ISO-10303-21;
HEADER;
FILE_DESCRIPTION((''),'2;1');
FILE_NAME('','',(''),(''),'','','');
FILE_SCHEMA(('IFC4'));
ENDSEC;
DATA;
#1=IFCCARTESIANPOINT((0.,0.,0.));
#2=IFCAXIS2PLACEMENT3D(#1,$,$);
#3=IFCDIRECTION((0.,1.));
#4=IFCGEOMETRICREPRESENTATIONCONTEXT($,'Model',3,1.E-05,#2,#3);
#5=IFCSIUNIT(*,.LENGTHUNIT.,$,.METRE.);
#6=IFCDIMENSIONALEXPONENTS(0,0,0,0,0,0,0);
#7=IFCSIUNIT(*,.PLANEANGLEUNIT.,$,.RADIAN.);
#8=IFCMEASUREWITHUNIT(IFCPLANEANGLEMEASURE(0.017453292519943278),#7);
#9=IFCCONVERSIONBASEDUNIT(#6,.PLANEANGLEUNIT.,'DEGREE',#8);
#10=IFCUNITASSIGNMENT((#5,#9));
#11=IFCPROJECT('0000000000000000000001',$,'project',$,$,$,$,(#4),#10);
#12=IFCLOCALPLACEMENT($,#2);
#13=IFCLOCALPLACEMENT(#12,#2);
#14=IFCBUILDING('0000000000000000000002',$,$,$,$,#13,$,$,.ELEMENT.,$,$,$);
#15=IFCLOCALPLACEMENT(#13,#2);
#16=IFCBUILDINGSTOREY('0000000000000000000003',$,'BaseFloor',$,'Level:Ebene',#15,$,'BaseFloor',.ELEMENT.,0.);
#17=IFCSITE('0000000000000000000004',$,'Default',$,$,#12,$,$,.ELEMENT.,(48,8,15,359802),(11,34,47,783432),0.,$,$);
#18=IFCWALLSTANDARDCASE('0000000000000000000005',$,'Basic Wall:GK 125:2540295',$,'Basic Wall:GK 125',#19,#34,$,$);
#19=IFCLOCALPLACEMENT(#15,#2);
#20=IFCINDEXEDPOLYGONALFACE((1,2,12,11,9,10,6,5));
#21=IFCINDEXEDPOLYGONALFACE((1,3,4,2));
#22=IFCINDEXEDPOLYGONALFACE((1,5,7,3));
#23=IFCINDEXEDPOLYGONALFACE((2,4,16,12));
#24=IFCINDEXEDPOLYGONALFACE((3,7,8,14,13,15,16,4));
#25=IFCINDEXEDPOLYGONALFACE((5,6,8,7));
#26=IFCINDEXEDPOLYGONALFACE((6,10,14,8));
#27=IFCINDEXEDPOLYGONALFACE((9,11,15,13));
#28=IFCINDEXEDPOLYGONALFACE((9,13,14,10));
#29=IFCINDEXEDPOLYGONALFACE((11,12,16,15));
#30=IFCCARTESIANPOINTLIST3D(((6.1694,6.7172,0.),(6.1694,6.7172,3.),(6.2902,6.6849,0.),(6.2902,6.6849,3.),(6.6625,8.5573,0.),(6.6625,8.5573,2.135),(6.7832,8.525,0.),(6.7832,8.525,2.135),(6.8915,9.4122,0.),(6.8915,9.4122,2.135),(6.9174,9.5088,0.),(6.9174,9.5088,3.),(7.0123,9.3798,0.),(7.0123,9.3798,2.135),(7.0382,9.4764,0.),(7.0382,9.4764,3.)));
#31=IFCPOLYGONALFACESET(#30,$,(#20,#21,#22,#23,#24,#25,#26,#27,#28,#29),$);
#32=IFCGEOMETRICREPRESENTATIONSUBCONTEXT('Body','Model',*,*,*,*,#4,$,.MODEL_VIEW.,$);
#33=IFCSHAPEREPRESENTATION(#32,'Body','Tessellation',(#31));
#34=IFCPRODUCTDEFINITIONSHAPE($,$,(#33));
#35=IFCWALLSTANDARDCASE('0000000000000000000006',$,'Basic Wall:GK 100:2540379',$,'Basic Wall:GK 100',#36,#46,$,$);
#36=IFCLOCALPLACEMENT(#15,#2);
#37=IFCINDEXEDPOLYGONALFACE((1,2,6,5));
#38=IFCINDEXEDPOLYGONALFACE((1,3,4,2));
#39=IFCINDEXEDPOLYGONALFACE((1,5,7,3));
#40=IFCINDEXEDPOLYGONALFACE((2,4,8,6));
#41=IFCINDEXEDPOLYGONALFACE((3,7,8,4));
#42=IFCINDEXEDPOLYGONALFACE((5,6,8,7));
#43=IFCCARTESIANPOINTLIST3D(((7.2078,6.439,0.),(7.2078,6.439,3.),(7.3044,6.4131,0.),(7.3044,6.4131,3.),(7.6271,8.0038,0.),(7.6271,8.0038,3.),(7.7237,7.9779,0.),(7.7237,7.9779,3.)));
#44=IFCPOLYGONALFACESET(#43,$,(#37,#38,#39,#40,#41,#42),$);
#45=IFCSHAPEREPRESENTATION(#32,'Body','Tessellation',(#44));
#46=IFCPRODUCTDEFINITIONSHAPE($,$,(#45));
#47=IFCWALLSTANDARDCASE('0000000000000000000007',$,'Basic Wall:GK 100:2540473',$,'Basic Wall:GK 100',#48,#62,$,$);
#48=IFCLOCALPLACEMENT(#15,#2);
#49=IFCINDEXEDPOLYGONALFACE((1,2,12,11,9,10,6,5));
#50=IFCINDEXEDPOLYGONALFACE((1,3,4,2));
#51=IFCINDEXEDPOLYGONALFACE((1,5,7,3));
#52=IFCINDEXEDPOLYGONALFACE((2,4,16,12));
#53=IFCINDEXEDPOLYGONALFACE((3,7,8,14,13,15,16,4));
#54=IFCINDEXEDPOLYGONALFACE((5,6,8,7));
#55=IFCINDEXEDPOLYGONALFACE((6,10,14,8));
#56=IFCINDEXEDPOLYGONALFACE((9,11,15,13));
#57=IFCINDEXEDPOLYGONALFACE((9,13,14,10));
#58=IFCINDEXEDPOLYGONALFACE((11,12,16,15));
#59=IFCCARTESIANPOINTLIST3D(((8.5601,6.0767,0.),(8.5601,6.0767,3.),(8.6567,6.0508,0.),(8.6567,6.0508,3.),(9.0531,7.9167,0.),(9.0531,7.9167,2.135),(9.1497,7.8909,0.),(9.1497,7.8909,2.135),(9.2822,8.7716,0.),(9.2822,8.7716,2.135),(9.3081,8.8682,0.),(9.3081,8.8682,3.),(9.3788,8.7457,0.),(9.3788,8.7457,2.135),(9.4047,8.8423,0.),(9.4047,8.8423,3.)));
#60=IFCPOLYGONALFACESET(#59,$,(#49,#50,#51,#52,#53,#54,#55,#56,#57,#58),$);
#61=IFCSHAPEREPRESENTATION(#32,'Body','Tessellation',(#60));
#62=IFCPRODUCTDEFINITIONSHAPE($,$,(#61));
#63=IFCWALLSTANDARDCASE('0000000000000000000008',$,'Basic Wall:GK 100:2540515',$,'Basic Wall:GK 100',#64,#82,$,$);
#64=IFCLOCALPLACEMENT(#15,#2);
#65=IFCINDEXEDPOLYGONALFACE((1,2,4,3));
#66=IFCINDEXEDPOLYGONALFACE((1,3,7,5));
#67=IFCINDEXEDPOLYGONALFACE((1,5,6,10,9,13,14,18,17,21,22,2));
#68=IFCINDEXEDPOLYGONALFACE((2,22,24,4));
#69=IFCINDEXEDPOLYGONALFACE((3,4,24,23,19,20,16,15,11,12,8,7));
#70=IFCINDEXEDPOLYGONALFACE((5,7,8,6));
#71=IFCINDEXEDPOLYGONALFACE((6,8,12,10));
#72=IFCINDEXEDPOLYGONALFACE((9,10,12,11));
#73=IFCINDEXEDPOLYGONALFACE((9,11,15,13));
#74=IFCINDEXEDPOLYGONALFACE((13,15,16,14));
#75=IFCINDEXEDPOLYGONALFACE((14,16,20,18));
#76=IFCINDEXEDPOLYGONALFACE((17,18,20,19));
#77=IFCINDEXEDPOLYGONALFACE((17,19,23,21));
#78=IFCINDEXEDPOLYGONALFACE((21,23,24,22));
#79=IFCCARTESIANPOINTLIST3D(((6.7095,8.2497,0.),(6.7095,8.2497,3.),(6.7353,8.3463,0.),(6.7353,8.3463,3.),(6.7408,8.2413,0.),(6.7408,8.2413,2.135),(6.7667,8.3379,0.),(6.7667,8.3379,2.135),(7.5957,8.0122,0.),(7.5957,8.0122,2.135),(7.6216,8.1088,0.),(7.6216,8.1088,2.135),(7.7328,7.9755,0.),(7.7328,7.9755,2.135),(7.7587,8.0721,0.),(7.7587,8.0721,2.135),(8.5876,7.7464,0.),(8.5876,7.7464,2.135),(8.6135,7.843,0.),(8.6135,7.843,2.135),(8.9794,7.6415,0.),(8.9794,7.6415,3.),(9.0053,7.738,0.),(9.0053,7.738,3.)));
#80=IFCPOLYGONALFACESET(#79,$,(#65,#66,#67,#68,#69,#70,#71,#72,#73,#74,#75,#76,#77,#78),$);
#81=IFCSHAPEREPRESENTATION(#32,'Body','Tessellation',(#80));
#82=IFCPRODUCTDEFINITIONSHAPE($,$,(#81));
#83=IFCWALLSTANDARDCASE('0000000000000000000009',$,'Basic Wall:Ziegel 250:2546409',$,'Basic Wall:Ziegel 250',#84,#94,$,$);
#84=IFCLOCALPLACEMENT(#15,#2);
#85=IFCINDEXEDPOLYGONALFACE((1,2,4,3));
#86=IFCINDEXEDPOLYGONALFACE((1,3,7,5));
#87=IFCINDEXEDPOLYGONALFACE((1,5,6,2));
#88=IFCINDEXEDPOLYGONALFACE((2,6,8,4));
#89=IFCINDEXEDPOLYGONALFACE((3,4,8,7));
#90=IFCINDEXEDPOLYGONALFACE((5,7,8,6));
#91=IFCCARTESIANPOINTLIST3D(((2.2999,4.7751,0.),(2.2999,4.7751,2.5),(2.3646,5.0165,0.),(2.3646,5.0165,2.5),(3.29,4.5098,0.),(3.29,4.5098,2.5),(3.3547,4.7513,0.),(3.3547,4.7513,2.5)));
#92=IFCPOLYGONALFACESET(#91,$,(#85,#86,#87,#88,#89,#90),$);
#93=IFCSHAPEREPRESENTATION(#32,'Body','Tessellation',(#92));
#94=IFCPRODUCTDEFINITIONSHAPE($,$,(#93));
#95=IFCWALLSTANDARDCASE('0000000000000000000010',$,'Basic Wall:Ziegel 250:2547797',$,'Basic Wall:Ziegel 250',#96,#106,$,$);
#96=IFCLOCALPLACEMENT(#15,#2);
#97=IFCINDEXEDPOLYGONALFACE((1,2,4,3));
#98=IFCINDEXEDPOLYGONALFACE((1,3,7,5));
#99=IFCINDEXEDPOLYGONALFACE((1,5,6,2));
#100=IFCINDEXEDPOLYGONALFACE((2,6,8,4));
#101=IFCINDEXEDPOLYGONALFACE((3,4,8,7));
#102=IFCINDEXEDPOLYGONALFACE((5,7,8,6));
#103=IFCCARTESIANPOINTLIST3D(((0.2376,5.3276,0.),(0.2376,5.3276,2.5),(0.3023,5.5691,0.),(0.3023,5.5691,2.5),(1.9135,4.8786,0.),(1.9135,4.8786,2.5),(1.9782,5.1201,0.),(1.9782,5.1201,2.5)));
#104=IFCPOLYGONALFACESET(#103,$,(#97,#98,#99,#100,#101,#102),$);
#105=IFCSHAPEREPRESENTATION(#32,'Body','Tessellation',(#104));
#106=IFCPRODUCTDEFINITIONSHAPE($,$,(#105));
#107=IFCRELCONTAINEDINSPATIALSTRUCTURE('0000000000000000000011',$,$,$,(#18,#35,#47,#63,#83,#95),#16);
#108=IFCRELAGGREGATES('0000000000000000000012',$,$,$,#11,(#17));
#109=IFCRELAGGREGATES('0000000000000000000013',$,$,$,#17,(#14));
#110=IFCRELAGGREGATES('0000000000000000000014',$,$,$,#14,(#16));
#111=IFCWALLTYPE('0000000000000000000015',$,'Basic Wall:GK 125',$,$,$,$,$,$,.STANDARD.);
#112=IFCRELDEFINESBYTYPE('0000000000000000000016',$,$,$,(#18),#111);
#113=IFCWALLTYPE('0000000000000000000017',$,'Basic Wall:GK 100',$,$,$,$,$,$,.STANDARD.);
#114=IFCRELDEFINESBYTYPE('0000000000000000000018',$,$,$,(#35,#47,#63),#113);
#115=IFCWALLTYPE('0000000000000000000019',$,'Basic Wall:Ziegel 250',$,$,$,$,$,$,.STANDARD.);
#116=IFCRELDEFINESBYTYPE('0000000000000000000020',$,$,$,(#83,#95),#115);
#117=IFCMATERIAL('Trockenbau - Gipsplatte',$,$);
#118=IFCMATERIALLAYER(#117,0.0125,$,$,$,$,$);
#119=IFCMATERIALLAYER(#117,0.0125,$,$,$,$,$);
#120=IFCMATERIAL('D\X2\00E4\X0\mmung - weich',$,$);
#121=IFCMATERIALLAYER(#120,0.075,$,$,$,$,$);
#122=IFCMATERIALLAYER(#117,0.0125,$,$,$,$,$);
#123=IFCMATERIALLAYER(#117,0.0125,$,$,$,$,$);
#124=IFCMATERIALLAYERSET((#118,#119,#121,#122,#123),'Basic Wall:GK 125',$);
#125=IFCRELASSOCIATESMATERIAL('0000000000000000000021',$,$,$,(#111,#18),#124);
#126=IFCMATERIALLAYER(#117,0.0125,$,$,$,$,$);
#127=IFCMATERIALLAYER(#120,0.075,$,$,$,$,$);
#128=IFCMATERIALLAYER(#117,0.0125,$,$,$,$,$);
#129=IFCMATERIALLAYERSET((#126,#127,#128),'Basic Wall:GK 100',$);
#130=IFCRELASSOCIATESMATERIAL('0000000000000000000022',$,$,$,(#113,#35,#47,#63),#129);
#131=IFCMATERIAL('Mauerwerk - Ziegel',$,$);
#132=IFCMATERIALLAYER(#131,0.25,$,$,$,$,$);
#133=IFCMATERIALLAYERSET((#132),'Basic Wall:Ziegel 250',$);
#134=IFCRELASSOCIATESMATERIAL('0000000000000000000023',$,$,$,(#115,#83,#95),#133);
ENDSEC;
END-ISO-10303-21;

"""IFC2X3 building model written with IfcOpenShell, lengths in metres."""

from ifc_helpers import new_model, entity, si_unit, converted_unit, direction, frame, frame_2d, origin, place, context, subcontext, project, spatial, rectangle, extrude, material, layer, layer_set, layer_usage, type_object, element, save


model = new_model("IFC2X3")

# Units and contexts
model_context = context("Model", 3, precision=1e-05, world=origin(), true_north=direction((0.0, 1.0)))
body_context = subcontext(model_context, "Body", "Model", "MODEL_VIEW")
ifc_project = project(units=[si_unit("LENGTHUNIT", "METRE"), converted_unit("PLANEANGLEUNIT", "DEGREE", entity("IfcPlaneAngleMeasure", 0.017453292519943278), si_unit("PLANEANGLEUNIT", "RADIAN"), dimensions=[0, 0, 0, 0, 0, 0, 0])], contexts=[model_context])

# Site, building, storey
site_placement = place(None, origin())
site = spatial("IfcSite", under=ifc_project, at=site_placement, Name="Default", CompositionType="ELEMENT", RefLatitude=(48, 8, 15, 359802), RefLongitude=(11, 34, 47, 783432), RefElevation=0.0)
building_placement = place(site_placement, origin())
building = spatial("IfcBuilding", under=site, at=building_placement, CompositionType="ELEMENT")
storey_placement = place(building_placement, origin())
storey = spatial("IfcBuildingStorey", under=building, at=storey_placement, Name="BaseFloor", ObjectType="Level:Ebene", LongName="BaseFloor", CompositionType="ELEMENT", Elevation=0.0)

# Shared definitions
ifc_material_1 = material(Name="Mauerwerk - Ziegel")

# Wall, opening
ifc_material_2 = material(Name="Trockenbau - Gipsplatte")
ifc_layer_1 = layer(ifc_material_2, 0.0125)
ifc_layer_2 = layer(ifc_material_2, 0.0125)
ifc_material_3 = material(Name="Dämmung - weich")
ifc_layer_3 = layer(ifc_material_3, 0.075)
ifc_layer_4 = layer(ifc_material_2, 0.0125)
ifc_layer_5 = layer(ifc_material_2, 0.0125)
ifc_layer_set_1 = layer_set([ifc_layer_1, ifc_layer_2, ifc_layer_3, ifc_layer_4, ifc_layer_5], Name="Basic Wall:GK 125")
ifc_layer_usage_1 = layer_usage(ifc_layer_set_1, "AXIS2", "NEGATIVE", 0.0625)
wall_type_1 = type_object("IfcWallType", Name="Basic Wall:GK 125", PredefinedType="STANDARD", material=ifc_layer_set_1)
wall_1_placement = place(storey_placement, frame((6.2298, 6.7011, 0.0), z_axis=(0.0, 0.0, 1.0), x_axis=(0.258819, 0.965926, 0.0)))
wall_1 = element("IfcWallStandardCase", 1, at=wall_1_placement, inside=storey, type_object=wall_type_1, material=ifc_layer_usage_1, Name="Basic Wall:GK 125:2540295", ObjectType="Basic Wall:GK 125", context=body_context, shape_type="SweptSolid", body=[
    extrude(rectangle(XDim=2.89, YDim=0.125, at=frame_2d((1.445, 0.0), x_axis=(-1.0, 0.0))), origin(), (0.0, 0.0, 1.0), 3.0),
])
opening_1_placement = place(wall_1_placement, frame((1.905, -0.0625, -0.18)))
element("IfcOpeningElement", 2, at=opening_1_placement, cuts=wall_1, ObjectType="Opening", context=body_context, shape_type="SweptSolid", body=[
    extrude(rectangle(XDim=2.315, YDim=0.885, at=frame_2d((1.1575, 0.4425), x_axis=(-1.0, 0.0))), frame((0.0, 0.0, 0.0), z_axis=(0.0, 1.0, 0.0), x_axis=(0.0, 0.0, 1.0)), (0.0, 0.0, 1.0), 0.125),
])

# Wall
ifc_layer_6 = layer(ifc_material_2, 0.0125)
ifc_layer_7 = layer(ifc_material_3, 0.075)
ifc_layer_8 = layer(ifc_material_2, 0.0125)
ifc_layer_set_2 = layer_set([ifc_layer_6, ifc_layer_7, ifc_layer_8], Name="Basic Wall:GK 100")
ifc_layer_usage_2 = layer_usage(ifc_layer_set_2, "AXIS2", "NEGATIVE", 0.05)
wall_type_2 = type_object("IfcWallType", Name="Basic Wall:GK 100", PredefinedType="STANDARD", material=ifc_layer_set_2)
wall_2_placement = place(storey_placement, frame((7.2561, 6.4261, 0.0), z_axis=(0.0, 0.0, 1.0), x_axis=(0.258819, 0.965926, 0.0)))
element("IfcWallStandardCase", 3, at=wall_2_placement, inside=storey, type_object=wall_type_2, material=ifc_layer_usage_2, Name="Basic Wall:GK 100:2540379", ObjectType="Basic Wall:GK 100", context=body_context, shape_type="SweptSolid", body=[
    extrude(rectangle(XDim=1.62, YDim=0.1, at=frame_2d((0.81, 0.0), x_axis=(-1.0, 0.0))), origin(), (0.0, 0.0, 1.0), 3.0),
])

# Wall, opening
ifc_layer_usage_3 = layer_usage(ifc_layer_set_2, "AXIS2", "NEGATIVE", 0.05)
wall_3_placement = place(storey_placement, frame((8.6084, 6.0637, 0.0), z_axis=(0.0, 0.0, 1.0), x_axis=(0.258819, 0.965926, 0.0)))
wall_3 = element("IfcWallStandardCase", 4, at=wall_3_placement, inside=storey, type_object=wall_type_2, material=ifc_layer_usage_3, Name="Basic Wall:GK 100:2540473", ObjectType="Basic Wall:GK 100", context=body_context, shape_type="SweptSolid", body=[
    extrude(rectangle(XDim=2.89, YDim=0.1, at=frame_2d((1.445, 0.0), x_axis=(-1.0, 0.0))), origin(), (0.0, 0.0, 1.0), 3.0),
])
opening_2_placement = place(wall_3_placement, frame((2.79, 0.05, -0.18)))
element("IfcOpeningElement", 5, at=opening_2_placement, cuts=wall_3, ObjectType="Opening", context=body_context, shape_type="SweptSolid", body=[
    extrude(rectangle(XDim=2.315, YDim=0.885, at=frame_2d((1.1575, 0.4425), x_axis=(-1.0, 0.0))), frame((0.0, 0.0, 0.0), z_axis=(0.0, -1.0, 0.0), x_axis=(0.0, 0.0, 1.0)), (0.0, 0.0, 1.0), 0.1),
])

# Wall, openings
ifc_layer_usage_4 = layer_usage(ifc_layer_set_2, "AXIS2", "NEGATIVE", 0.05)
wall_4_placement = place(storey_placement, frame((8.9923, 7.6898, 0.0), z_axis=(0.0, 0.0, 1.0), x_axis=(-0.965926, 0.258819, 0.0)))
wall_4 = element("IfcWallStandardCase", 6, at=wall_4_placement, inside=storey, type_object=wall_type_2, material=ifc_layer_usage_4, Name="Basic Wall:GK 100:2540515", ObjectType="Basic Wall:GK 100", context=body_context, shape_type="SweptSolid", body=[
    extrude(rectangle(XDim=2.35, YDim=0.1, at=frame_2d((1.175, 0.0), x_axis=(1.0, 0.0))), origin(), (0.0, 0.0, 1.0), 3.0),
])
opening_3_placement = place(wall_4_placement, frame((1.4325, -0.05, -0.18)))
element("IfcOpeningElement", 7, at=opening_3_placement, cuts=wall_4, ObjectType="Opening", context=body_context, shape_type="SweptSolid", body=[
    extrude(rectangle(XDim=2.315, YDim=0.885, at=frame_2d((1.1575, 0.4425), x_axis=(-1.0, 0.0))), frame((0.0, 0.0, 0.0), z_axis=(0.0, 1.0, 0.0), x_axis=(0.0, 0.0, 1.0)), (0.0, 0.0, 1.0), 0.1),
])
opening_4_placement = place(wall_4_placement, frame((0.4056, -0.05, -0.18)))
element("IfcOpeningElement", 8, at=opening_4_placement, cuts=wall_4, ObjectType="Opening", context=body_context, shape_type="SweptSolid", body=[
    extrude(rectangle(XDim=2.315, YDim=0.885, at=frame_2d((1.1575, 0.4425), x_axis=(-1.0, 0.0))), frame((0.0, 0.0, 0.0), z_axis=(0.0, 1.0, 0.0), x_axis=(0.0, 0.0, 1.0)), (0.0, 0.0, 1.0), 0.1),
])

# Walls
ifc_layer_9 = layer(ifc_material_1, 0.25)
ifc_layer_set_3 = layer_set([ifc_layer_9], Name="Basic Wall:Ziegel 250")
ifc_layer_usage_5 = layer_usage(ifc_layer_set_3, "AXIS2", "NEGATIVE", 0.125)
wall_type_3 = type_object("IfcWallType", Name="Basic Wall:Ziegel 250", PredefinedType="STANDARD", material=ifc_layer_set_3)
wall_5_placement = place(storey_placement, frame((3.3223, 4.6305, 0.0), z_axis=(0.0, 0.0, 1.0), x_axis=(-0.965926, 0.258819, 0.0)))
element("IfcWallStandardCase", 9, at=wall_5_placement, inside=storey, type_object=wall_type_3, material=ifc_layer_usage_5, Name="Basic Wall:Ziegel 250:2546409", ObjectType="Basic Wall:Ziegel 250", context=body_context, shape_type="SweptSolid", body=[
    extrude(rectangle(XDim=1.025, YDim=0.25, at=frame_2d((0.5125, 0.0), x_axis=(-1.0, 0.0))), origin(), (0.0, 0.0, 1.0), 2.5),
])
ifc_layer_usage_6 = layer_usage(ifc_layer_set_3, "AXIS2", "NEGATIVE", 0.125)
wall_6_placement = place(storey_placement, frame((1.9459, 4.9993, 0.0), z_axis=(0.0, 0.0, 1.0), x_axis=(-0.965926, 0.258819, 0.0)))
element("IfcWallStandardCase", 10, at=wall_6_placement, inside=storey, type_object=wall_type_3, material=ifc_layer_usage_6, Name="Basic Wall:Ziegel 250:2547797", ObjectType="Basic Wall:Ziegel 250", context=body_context, shape_type="SweptSolid", body=[
    extrude(rectangle(XDim=1.735, YDim=0.25, at=frame_2d((0.8675, 0.0), x_axis=(-1.0, 0.0))), origin(), (0.0, 0.0, 1.0), 2.5),
])

save(model, "model.ifc")
